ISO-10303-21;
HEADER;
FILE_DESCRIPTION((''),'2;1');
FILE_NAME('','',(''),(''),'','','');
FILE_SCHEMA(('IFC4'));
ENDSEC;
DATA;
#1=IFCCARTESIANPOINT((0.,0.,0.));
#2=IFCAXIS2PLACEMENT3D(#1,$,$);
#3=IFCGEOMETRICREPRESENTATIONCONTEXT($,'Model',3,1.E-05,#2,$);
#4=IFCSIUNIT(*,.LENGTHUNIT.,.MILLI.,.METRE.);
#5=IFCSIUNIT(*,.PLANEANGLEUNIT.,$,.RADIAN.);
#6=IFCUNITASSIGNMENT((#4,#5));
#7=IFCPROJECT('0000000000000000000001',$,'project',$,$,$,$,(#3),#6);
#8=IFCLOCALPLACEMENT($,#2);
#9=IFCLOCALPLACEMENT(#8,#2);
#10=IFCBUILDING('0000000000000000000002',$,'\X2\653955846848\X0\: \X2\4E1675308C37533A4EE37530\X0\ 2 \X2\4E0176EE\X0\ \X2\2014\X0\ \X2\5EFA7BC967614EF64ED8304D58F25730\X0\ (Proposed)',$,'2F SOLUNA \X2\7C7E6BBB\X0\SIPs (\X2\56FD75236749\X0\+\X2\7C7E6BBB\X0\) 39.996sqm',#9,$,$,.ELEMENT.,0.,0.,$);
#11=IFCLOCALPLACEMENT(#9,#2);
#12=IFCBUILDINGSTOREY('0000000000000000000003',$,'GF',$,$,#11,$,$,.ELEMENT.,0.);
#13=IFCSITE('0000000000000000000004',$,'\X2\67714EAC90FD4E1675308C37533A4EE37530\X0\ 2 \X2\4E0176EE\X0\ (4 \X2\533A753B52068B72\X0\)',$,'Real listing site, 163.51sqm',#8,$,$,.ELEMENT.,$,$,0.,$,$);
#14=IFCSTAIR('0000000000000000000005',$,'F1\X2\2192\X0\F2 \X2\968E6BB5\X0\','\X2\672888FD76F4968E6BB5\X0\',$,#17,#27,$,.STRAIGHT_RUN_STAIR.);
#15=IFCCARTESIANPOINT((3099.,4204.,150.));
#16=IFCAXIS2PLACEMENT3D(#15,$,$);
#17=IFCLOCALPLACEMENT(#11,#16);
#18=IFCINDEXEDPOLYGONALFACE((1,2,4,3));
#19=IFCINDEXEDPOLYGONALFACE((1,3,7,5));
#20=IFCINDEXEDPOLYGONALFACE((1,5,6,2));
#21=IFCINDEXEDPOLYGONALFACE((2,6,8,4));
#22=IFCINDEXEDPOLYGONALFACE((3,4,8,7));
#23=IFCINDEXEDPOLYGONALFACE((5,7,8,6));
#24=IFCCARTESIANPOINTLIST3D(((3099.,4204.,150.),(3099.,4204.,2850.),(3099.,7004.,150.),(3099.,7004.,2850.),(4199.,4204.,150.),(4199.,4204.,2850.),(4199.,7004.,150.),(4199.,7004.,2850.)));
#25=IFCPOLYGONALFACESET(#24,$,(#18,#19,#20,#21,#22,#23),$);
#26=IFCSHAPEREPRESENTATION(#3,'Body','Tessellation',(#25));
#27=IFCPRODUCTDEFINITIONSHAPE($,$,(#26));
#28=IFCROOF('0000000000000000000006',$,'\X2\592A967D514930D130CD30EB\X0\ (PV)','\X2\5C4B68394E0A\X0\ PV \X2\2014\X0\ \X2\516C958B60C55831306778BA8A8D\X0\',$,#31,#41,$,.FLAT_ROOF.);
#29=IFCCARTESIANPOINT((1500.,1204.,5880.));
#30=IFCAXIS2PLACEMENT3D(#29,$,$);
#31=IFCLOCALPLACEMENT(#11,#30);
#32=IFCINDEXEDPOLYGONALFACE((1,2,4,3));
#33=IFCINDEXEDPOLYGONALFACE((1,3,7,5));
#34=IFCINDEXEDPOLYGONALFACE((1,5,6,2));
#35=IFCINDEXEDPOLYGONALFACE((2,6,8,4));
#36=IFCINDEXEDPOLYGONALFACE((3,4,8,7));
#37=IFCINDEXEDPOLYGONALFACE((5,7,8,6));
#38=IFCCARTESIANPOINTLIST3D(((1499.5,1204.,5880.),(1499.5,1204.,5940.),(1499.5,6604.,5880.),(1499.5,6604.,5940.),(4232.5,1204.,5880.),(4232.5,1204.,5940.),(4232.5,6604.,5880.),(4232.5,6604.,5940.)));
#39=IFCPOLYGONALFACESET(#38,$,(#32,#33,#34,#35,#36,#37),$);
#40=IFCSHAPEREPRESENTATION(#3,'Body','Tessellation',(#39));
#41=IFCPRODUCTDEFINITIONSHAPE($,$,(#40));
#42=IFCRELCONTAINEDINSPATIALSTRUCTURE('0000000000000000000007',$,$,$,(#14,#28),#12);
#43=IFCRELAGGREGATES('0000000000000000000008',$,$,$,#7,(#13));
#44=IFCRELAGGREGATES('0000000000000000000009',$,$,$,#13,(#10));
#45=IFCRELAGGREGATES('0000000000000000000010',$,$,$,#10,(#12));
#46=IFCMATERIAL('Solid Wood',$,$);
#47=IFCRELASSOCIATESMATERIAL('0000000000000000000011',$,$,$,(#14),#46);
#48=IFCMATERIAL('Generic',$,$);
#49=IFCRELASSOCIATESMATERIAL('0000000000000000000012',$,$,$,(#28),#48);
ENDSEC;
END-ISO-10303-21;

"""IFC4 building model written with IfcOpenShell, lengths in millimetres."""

from ifc_helpers import new_model, si_unit, frame, frame_2d, origin, place, context, project, spatial, rectangle, extrude, material, element, save


model = new_model("IFC4")

# Units and contexts
model_context = context("Model", 3, precision=1e-05, world=origin())
ifc_project = project(units=[si_unit("LENGTHUNIT", "METRE", prefix="MILLI"), si_unit("PLANEANGLEUNIT", "RADIAN")], contexts=[model_context])

# Site, building, storey
site_placement = place(None, origin())
site = spatial("IfcSite", under=ifc_project, at=site_placement, Name="東京都世田谷区代田 2 丁目 (4 区画分譲)", ObjectType="Real listing site, 163.51sqm", CompositionType="ELEMENT", RefElevation=0.0)
building_placement = place(site_placement, origin())
building = spatial("IfcBuilding", under=site, at=building_placement, Name="改善案: 世田谷区代田 2 丁目 — 建築条件付き売地 (Proposed)", ObjectType="2F SOLUNA 籾殻SIPs (国産杉+籾殻) 39.996sqm", CompositionType="ELEMENT", ElevationOfRefHeight=0.0, ElevationOfTerrain=0.0)
storey_placement = place(building_placement, origin())
storey = spatial("IfcBuildingStorey", under=building, at=storey_placement, Name="GF", CompositionType="ELEMENT", Elevation=0.0)

# Shared definitions
ifc_material_1 = material(Name="Generic")

# Stair
ifc_material_2 = material(Name="Solid Wood")
stair_placement = place(storey_placement, frame((3099.0, 4204.0, 150.0)))
element("IfcStair", 1, at=stair_placement, inside=storey, material=ifc_material_2, Name="F1→F2 階段", Description="木製直階段", PredefinedType="STRAIGHT_RUN_STAIR", context=model_context, shape_type="SweptSolid", body=[
    extrude(rectangle(XDim=1100.0, YDim=2800.0, at=frame_2d((550.0, 1400.0))), frame((3099.0, 4204.0, 150.0)), (0.0, 0.0, 1.0), 2700.0),
])

# Roof
roof_placement = place(storey_placement, frame((1500.0, 1204.0, 5880.0)))
element("IfcRoof", 2, at=roof_placement, inside=storey, material=ifc_material_1, Name="太陽光パネル (PV)", Description="屋根上 PV — 公開情報で確認", PredefinedType="FLAT_ROOF", context=model_context, shape_type="SweptSolid", body=[
    extrude(rectangle(XDim=2733.0, YDim=5400.0, at=frame_2d((1366.0, 2700.0))), frame((1500.0, 1204.0, 5880.0)), (0.0, 0.0, 1.0), 60.0),
])

save(model, "model.ifc")
